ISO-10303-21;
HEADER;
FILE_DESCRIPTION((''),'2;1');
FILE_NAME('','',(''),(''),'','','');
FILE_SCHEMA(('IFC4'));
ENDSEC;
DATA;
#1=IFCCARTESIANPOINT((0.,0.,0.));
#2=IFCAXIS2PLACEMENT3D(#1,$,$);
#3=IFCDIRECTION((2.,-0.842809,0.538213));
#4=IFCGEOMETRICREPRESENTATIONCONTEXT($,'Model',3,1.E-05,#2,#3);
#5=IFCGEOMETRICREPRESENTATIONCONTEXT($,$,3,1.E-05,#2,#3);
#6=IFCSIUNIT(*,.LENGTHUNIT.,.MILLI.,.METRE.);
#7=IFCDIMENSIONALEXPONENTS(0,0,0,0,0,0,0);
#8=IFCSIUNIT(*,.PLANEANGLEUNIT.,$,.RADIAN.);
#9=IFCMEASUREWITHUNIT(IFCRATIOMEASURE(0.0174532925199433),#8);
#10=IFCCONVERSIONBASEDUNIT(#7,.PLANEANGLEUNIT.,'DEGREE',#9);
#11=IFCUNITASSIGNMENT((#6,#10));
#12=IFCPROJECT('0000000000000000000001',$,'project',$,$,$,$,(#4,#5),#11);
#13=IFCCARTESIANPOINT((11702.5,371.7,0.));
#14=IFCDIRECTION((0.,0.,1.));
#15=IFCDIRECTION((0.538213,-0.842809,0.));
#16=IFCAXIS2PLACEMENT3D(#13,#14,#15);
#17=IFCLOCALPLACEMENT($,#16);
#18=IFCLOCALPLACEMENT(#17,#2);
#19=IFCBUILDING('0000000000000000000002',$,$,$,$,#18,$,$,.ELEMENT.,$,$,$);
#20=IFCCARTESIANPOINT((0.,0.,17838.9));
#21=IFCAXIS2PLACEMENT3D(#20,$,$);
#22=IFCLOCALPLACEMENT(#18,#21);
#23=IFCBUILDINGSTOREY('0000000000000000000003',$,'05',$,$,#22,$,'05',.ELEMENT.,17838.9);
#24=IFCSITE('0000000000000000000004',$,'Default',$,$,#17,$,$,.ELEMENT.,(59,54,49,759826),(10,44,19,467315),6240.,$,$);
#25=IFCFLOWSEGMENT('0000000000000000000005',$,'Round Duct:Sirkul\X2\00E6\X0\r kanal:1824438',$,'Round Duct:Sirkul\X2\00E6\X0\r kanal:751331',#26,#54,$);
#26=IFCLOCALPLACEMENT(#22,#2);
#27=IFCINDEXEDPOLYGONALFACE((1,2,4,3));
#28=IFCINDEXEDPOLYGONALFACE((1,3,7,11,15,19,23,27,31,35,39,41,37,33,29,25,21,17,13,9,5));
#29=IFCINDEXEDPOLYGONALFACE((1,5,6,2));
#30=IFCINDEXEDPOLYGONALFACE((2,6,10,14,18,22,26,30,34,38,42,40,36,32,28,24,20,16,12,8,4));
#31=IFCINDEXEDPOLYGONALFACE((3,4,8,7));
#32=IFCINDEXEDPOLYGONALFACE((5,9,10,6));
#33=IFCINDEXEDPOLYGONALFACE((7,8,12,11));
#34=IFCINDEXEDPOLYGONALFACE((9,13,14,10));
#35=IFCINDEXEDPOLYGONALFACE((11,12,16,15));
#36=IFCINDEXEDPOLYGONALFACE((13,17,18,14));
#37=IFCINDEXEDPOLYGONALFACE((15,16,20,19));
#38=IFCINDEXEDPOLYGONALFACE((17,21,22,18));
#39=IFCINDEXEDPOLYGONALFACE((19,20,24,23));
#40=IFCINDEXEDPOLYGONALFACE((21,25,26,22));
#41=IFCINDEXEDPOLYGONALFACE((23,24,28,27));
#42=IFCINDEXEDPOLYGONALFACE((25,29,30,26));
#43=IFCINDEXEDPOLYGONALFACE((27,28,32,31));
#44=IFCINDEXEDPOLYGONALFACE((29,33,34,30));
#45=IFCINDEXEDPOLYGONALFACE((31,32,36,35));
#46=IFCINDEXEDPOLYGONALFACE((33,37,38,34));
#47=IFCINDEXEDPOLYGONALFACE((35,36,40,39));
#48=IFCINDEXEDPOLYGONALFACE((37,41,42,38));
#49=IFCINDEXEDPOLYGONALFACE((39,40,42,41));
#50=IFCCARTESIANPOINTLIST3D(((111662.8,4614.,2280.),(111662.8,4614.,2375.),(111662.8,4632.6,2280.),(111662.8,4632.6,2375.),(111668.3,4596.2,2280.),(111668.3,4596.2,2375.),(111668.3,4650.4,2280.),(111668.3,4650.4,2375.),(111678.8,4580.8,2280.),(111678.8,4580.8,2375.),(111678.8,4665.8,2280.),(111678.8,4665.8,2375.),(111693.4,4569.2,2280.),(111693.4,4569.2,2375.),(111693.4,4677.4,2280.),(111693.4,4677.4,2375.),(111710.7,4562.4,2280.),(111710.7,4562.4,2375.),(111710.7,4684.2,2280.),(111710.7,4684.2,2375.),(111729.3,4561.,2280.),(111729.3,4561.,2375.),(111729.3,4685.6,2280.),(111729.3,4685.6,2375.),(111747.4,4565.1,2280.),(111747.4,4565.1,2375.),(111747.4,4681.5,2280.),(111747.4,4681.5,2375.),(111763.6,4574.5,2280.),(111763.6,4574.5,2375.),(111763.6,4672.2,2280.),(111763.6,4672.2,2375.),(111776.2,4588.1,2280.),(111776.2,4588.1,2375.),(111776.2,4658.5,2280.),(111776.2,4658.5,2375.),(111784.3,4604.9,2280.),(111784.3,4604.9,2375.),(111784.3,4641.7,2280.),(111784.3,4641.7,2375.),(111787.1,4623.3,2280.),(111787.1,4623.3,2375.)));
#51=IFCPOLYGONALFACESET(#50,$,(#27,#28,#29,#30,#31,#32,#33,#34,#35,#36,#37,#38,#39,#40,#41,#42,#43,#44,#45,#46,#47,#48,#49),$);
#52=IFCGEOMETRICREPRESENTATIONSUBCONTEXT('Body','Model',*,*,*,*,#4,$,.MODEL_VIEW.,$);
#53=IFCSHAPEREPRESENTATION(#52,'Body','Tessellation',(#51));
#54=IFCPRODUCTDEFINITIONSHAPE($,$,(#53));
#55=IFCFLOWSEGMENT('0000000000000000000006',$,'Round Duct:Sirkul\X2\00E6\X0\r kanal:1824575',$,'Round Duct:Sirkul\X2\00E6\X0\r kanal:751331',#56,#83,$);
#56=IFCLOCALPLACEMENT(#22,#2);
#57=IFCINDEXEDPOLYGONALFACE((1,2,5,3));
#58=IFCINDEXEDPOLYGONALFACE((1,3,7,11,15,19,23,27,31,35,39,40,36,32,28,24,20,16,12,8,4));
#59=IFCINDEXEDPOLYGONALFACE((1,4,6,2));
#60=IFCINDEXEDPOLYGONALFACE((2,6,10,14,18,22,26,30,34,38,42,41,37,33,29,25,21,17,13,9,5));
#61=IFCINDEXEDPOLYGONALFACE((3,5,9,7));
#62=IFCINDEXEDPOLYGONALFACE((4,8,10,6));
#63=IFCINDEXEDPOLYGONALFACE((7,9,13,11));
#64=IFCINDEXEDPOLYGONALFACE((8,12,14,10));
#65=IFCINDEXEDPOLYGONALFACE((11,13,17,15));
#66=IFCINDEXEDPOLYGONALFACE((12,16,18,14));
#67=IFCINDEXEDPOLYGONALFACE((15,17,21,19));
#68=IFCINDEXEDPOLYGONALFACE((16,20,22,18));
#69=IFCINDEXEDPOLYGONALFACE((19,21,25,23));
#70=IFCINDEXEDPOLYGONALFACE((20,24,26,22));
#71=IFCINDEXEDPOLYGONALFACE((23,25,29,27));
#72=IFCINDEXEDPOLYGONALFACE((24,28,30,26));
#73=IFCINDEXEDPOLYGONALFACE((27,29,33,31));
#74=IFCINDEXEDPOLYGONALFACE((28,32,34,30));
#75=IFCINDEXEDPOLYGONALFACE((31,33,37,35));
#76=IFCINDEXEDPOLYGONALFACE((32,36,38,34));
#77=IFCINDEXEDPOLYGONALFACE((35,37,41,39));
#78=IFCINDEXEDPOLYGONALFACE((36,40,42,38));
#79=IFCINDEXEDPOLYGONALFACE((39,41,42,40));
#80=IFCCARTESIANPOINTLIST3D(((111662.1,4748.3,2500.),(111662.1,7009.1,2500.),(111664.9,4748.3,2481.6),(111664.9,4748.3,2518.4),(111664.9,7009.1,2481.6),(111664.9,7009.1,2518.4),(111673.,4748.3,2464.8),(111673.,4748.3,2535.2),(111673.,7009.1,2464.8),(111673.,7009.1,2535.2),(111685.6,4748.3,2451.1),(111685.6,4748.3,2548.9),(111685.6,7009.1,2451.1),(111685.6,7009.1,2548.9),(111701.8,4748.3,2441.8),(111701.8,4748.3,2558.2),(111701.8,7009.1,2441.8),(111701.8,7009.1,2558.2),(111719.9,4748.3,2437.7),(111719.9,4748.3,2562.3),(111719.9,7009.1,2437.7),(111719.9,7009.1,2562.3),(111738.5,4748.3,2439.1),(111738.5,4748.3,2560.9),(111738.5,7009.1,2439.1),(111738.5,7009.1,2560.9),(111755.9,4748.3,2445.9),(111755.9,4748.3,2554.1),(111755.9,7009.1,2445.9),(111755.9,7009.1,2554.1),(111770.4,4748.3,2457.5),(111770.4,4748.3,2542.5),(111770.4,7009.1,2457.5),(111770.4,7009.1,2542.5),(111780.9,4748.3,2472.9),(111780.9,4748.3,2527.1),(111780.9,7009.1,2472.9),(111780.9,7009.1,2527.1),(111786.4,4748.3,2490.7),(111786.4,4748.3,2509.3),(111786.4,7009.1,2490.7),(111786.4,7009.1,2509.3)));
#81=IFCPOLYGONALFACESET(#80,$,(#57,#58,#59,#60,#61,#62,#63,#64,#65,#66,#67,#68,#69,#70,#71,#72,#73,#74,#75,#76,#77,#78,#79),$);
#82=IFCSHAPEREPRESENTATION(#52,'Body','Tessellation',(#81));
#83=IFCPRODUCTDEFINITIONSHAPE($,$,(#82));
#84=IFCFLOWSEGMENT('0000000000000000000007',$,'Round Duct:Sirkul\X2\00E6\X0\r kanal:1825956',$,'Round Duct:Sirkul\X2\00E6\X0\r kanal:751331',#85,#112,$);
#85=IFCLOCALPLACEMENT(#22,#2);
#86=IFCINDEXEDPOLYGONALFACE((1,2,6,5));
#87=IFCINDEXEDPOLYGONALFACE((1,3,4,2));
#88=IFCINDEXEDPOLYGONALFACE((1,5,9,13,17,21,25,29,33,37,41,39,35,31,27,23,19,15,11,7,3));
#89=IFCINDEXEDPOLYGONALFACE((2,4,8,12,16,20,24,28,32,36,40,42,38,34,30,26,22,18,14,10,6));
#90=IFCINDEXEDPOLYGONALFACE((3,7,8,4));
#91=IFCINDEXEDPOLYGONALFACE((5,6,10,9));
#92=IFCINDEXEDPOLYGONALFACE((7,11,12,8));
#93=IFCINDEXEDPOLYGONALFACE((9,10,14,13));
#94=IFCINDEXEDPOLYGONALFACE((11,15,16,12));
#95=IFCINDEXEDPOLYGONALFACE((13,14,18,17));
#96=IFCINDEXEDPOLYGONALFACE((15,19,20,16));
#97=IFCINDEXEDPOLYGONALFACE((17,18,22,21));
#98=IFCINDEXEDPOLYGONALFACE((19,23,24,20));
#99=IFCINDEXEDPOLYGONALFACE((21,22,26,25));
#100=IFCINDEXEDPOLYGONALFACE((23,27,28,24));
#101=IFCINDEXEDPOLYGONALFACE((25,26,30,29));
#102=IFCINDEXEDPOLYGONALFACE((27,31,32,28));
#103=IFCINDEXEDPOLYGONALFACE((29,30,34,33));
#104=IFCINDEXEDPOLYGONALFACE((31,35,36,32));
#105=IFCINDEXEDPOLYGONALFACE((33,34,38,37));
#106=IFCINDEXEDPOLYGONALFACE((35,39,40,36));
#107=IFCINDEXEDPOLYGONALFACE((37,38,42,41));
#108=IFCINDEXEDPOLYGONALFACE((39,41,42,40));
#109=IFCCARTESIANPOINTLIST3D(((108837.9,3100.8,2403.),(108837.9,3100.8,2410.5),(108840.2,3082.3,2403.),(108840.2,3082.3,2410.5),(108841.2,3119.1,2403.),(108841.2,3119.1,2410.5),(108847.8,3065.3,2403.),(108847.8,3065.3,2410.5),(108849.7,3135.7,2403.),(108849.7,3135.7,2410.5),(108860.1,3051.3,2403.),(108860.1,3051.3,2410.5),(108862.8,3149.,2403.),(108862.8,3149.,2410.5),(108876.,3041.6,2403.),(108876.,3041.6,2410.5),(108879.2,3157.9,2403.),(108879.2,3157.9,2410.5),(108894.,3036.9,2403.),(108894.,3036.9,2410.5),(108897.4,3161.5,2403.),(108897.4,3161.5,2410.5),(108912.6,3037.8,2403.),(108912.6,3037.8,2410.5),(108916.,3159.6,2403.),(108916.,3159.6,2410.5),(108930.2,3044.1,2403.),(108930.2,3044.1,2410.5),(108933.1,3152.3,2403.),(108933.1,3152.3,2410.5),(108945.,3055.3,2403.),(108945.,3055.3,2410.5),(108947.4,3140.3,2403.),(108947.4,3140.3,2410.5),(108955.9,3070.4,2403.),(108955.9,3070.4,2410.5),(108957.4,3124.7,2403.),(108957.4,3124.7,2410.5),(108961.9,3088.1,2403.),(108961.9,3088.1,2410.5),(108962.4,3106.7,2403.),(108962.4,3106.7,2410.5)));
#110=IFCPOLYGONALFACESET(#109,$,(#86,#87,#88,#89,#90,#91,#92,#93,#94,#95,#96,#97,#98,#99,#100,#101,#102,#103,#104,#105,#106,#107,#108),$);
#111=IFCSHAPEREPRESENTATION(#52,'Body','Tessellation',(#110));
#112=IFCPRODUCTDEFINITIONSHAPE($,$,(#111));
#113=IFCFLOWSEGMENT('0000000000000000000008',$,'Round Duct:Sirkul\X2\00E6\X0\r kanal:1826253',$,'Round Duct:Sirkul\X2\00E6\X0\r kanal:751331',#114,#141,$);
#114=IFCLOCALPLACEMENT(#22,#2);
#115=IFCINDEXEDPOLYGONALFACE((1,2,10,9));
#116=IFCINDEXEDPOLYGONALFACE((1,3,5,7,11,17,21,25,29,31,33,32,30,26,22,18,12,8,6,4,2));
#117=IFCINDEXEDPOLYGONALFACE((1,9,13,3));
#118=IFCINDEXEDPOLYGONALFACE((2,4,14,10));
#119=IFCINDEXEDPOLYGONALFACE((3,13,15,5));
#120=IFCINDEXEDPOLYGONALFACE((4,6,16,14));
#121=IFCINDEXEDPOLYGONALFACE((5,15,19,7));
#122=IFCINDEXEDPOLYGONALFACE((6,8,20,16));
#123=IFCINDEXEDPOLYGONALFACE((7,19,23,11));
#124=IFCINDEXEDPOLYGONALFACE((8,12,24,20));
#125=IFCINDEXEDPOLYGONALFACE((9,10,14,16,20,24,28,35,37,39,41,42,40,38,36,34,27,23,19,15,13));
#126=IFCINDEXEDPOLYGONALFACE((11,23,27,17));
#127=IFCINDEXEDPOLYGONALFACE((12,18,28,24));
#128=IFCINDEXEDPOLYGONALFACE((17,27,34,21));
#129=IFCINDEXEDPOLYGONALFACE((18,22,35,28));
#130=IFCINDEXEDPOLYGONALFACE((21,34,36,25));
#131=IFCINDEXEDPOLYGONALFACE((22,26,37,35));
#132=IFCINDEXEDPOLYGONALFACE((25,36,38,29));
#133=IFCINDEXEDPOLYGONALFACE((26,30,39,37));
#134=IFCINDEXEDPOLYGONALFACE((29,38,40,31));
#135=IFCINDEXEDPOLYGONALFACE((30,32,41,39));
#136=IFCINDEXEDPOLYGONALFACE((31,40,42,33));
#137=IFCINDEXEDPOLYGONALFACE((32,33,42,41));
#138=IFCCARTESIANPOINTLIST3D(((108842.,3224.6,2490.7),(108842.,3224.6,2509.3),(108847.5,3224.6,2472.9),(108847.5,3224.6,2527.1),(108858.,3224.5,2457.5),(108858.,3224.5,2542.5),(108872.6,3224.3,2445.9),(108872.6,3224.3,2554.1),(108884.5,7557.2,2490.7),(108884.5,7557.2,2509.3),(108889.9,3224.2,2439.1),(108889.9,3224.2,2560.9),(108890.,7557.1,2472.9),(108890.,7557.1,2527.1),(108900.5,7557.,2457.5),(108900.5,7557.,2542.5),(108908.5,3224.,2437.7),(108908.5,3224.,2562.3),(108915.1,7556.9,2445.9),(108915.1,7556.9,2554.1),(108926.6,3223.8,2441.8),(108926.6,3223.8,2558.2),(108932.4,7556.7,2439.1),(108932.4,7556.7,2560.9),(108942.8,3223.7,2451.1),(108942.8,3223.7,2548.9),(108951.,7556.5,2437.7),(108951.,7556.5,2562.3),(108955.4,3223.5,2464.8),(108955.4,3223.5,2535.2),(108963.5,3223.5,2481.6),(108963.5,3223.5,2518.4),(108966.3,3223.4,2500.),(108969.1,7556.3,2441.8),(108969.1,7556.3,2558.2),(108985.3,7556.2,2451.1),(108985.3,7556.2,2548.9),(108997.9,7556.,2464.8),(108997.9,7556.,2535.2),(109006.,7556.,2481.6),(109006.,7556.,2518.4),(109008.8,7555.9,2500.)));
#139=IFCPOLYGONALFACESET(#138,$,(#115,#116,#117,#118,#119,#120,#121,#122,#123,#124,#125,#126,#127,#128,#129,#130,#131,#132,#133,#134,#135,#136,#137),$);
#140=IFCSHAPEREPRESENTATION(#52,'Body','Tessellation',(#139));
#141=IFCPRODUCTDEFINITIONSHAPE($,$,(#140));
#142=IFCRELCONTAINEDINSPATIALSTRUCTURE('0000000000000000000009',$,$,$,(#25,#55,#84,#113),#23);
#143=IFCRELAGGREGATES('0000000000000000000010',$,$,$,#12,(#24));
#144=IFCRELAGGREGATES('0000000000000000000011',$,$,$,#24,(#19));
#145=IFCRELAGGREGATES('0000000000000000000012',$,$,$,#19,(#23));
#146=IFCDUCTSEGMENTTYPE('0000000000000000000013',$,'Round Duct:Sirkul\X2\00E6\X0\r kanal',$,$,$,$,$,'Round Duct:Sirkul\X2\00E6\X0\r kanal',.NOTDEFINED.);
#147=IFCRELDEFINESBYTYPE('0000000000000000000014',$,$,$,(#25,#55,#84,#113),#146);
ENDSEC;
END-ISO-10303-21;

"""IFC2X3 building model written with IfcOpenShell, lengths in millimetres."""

from ifc_helpers import new_model, entity, si_unit, converted_unit, direction, frame, frame_2d, origin, origin_2d_with_axis, place, context, subcontext, project, spatial, circle, extrude, type_object, element, save


model = new_model("IFC2X3")

# Units and contexts
model_context = context("Model", 3, precision=1e-05, world=origin(), true_north=direction((2.0, -0.842809, 0.538213)))
context_of_model = context(None, 3, precision=1e-05, world=origin(), true_north=direction((2.0, -0.842809, 0.538213)))
body_context = subcontext(model_context, "Body", "Model", "MODEL_VIEW")
ifc_project = project(units=[si_unit("LENGTHUNIT", "METRE", prefix="MILLI"), converted_unit("PLANEANGLEUNIT", "DEGREE", entity("IfcRatioMeasure", 0.0174532925199433), si_unit("PLANEANGLEUNIT", "RADIAN"), dimensions=[0, 0, 0, 0, 0, 0, 0])], contexts=[model_context, context_of_model])

# Site, building, storey
site_placement = place(None, frame((11702.5, 371.7, 0.0), z_axis=(0.0, 0.0, 1.0), x_axis=(0.538213, -0.842809, 0.0)))
site = spatial("IfcSite", under=ifc_project, at=site_placement, Name="Default", CompositionType="ELEMENT", RefLatitude=(59, 54, 49, 759826), RefLongitude=(10, 44, 19, 467315), RefElevation=6240.0)
building_placement = place(site_placement, origin())
building = spatial("IfcBuilding", under=site, at=building_placement, CompositionType="ELEMENT")
storey_placement = place(building_placement, frame((0.0, 0.0, 17838.9)))
storey = spatial("IfcBuildingStorey", under=building, at=storey_placement, Name="05", LongName="05", CompositionType="ELEMENT", Elevation=17838.9)

# Flow segments
duct_segment_type = type_object("IfcDuctSegmentType", Name="Round Duct:Sirkulær kanal", ElementType="Round Duct:Sirkulær kanal", PredefinedType="NOTDEFINED")
flow_segment_1_placement = place(storey_placement, origin())
element("IfcFlowSegment", 1, at=flow_segment_1_placement, inside=storey, type_object=duct_segment_type, Name="Round Duct:Sirkulær kanal:1824438", ObjectType="Round Duct:Sirkulær kanal:751331", context=body_context, shape_type="SweptSolid", body=[
    extrude(circle(Radius=62.5, at=frame_2d((0.0, 0.0), x_axis=(1.0, 0.0))), frame((111724.6, 4623.3, 2280.0)), (0.0, 0.0, 1.0), 95.0),
])
flow_segment_2_placement = place(storey_placement, origin())
element("IfcFlowSegment", 2, at=flow_segment_2_placement, inside=storey, type_object=duct_segment_type, Name="Round Duct:Sirkulær kanal:1824575", ObjectType="Round Duct:Sirkulær kanal:751331", context=body_context, shape_type="SweptSolid", body=[
    extrude(circle(Radius=62.5, at=frame_2d((0.0, 0.0), x_axis=(1.0, 0.0))), frame((111724.6, 4748.3, 2500.0), z_axis=(0.000001, 1.0, 0.0), x_axis=(-1.0, 0.000001, 0.0)), (0.0, 0.0, 1.0), 2260.8),
])
flow_segment_3_placement = place(storey_placement, origin())
element("IfcFlowSegment", 3, at=flow_segment_3_placement, inside=storey, type_object=duct_segment_type, Name="Round Duct:Sirkulær kanal:1825956", ObjectType="Round Duct:Sirkulær kanal:751331", context=body_context, shape_type="SweptSolid", body=[
    extrude(circle(Radius=62.5, at=origin_2d_with_axis()), frame((108900.4, 3099.1, 2403.0), z_axis=(0.0, 0.0, 1.0), x_axis=(-0.999628, 0.02726, 0.0)), (0.0, 0.0, 1.0), 7.5),
])
flow_segment_4_placement = place(storey_placement, origin())
element("IfcFlowSegment", 4, at=flow_segment_4_placement, inside=storey, type_object=duct_segment_type, Name="Round Duct:Sirkulær kanal:1826253", ObjectType="Round Duct:Sirkulær kanal:751331", context=body_context, shape_type="SweptSolid", body=[
    extrude(circle(Radius=62.5, at=origin_2d_with_axis()), frame((108903.8, 3224.0, 2500.0), z_axis=(0.00981, 0.999952, 0.0), x_axis=(0.999952, -0.00981, 0.0)), (0.0, 0.0, 1.0), 4332.7),
])

save(model, "model.ifc")
